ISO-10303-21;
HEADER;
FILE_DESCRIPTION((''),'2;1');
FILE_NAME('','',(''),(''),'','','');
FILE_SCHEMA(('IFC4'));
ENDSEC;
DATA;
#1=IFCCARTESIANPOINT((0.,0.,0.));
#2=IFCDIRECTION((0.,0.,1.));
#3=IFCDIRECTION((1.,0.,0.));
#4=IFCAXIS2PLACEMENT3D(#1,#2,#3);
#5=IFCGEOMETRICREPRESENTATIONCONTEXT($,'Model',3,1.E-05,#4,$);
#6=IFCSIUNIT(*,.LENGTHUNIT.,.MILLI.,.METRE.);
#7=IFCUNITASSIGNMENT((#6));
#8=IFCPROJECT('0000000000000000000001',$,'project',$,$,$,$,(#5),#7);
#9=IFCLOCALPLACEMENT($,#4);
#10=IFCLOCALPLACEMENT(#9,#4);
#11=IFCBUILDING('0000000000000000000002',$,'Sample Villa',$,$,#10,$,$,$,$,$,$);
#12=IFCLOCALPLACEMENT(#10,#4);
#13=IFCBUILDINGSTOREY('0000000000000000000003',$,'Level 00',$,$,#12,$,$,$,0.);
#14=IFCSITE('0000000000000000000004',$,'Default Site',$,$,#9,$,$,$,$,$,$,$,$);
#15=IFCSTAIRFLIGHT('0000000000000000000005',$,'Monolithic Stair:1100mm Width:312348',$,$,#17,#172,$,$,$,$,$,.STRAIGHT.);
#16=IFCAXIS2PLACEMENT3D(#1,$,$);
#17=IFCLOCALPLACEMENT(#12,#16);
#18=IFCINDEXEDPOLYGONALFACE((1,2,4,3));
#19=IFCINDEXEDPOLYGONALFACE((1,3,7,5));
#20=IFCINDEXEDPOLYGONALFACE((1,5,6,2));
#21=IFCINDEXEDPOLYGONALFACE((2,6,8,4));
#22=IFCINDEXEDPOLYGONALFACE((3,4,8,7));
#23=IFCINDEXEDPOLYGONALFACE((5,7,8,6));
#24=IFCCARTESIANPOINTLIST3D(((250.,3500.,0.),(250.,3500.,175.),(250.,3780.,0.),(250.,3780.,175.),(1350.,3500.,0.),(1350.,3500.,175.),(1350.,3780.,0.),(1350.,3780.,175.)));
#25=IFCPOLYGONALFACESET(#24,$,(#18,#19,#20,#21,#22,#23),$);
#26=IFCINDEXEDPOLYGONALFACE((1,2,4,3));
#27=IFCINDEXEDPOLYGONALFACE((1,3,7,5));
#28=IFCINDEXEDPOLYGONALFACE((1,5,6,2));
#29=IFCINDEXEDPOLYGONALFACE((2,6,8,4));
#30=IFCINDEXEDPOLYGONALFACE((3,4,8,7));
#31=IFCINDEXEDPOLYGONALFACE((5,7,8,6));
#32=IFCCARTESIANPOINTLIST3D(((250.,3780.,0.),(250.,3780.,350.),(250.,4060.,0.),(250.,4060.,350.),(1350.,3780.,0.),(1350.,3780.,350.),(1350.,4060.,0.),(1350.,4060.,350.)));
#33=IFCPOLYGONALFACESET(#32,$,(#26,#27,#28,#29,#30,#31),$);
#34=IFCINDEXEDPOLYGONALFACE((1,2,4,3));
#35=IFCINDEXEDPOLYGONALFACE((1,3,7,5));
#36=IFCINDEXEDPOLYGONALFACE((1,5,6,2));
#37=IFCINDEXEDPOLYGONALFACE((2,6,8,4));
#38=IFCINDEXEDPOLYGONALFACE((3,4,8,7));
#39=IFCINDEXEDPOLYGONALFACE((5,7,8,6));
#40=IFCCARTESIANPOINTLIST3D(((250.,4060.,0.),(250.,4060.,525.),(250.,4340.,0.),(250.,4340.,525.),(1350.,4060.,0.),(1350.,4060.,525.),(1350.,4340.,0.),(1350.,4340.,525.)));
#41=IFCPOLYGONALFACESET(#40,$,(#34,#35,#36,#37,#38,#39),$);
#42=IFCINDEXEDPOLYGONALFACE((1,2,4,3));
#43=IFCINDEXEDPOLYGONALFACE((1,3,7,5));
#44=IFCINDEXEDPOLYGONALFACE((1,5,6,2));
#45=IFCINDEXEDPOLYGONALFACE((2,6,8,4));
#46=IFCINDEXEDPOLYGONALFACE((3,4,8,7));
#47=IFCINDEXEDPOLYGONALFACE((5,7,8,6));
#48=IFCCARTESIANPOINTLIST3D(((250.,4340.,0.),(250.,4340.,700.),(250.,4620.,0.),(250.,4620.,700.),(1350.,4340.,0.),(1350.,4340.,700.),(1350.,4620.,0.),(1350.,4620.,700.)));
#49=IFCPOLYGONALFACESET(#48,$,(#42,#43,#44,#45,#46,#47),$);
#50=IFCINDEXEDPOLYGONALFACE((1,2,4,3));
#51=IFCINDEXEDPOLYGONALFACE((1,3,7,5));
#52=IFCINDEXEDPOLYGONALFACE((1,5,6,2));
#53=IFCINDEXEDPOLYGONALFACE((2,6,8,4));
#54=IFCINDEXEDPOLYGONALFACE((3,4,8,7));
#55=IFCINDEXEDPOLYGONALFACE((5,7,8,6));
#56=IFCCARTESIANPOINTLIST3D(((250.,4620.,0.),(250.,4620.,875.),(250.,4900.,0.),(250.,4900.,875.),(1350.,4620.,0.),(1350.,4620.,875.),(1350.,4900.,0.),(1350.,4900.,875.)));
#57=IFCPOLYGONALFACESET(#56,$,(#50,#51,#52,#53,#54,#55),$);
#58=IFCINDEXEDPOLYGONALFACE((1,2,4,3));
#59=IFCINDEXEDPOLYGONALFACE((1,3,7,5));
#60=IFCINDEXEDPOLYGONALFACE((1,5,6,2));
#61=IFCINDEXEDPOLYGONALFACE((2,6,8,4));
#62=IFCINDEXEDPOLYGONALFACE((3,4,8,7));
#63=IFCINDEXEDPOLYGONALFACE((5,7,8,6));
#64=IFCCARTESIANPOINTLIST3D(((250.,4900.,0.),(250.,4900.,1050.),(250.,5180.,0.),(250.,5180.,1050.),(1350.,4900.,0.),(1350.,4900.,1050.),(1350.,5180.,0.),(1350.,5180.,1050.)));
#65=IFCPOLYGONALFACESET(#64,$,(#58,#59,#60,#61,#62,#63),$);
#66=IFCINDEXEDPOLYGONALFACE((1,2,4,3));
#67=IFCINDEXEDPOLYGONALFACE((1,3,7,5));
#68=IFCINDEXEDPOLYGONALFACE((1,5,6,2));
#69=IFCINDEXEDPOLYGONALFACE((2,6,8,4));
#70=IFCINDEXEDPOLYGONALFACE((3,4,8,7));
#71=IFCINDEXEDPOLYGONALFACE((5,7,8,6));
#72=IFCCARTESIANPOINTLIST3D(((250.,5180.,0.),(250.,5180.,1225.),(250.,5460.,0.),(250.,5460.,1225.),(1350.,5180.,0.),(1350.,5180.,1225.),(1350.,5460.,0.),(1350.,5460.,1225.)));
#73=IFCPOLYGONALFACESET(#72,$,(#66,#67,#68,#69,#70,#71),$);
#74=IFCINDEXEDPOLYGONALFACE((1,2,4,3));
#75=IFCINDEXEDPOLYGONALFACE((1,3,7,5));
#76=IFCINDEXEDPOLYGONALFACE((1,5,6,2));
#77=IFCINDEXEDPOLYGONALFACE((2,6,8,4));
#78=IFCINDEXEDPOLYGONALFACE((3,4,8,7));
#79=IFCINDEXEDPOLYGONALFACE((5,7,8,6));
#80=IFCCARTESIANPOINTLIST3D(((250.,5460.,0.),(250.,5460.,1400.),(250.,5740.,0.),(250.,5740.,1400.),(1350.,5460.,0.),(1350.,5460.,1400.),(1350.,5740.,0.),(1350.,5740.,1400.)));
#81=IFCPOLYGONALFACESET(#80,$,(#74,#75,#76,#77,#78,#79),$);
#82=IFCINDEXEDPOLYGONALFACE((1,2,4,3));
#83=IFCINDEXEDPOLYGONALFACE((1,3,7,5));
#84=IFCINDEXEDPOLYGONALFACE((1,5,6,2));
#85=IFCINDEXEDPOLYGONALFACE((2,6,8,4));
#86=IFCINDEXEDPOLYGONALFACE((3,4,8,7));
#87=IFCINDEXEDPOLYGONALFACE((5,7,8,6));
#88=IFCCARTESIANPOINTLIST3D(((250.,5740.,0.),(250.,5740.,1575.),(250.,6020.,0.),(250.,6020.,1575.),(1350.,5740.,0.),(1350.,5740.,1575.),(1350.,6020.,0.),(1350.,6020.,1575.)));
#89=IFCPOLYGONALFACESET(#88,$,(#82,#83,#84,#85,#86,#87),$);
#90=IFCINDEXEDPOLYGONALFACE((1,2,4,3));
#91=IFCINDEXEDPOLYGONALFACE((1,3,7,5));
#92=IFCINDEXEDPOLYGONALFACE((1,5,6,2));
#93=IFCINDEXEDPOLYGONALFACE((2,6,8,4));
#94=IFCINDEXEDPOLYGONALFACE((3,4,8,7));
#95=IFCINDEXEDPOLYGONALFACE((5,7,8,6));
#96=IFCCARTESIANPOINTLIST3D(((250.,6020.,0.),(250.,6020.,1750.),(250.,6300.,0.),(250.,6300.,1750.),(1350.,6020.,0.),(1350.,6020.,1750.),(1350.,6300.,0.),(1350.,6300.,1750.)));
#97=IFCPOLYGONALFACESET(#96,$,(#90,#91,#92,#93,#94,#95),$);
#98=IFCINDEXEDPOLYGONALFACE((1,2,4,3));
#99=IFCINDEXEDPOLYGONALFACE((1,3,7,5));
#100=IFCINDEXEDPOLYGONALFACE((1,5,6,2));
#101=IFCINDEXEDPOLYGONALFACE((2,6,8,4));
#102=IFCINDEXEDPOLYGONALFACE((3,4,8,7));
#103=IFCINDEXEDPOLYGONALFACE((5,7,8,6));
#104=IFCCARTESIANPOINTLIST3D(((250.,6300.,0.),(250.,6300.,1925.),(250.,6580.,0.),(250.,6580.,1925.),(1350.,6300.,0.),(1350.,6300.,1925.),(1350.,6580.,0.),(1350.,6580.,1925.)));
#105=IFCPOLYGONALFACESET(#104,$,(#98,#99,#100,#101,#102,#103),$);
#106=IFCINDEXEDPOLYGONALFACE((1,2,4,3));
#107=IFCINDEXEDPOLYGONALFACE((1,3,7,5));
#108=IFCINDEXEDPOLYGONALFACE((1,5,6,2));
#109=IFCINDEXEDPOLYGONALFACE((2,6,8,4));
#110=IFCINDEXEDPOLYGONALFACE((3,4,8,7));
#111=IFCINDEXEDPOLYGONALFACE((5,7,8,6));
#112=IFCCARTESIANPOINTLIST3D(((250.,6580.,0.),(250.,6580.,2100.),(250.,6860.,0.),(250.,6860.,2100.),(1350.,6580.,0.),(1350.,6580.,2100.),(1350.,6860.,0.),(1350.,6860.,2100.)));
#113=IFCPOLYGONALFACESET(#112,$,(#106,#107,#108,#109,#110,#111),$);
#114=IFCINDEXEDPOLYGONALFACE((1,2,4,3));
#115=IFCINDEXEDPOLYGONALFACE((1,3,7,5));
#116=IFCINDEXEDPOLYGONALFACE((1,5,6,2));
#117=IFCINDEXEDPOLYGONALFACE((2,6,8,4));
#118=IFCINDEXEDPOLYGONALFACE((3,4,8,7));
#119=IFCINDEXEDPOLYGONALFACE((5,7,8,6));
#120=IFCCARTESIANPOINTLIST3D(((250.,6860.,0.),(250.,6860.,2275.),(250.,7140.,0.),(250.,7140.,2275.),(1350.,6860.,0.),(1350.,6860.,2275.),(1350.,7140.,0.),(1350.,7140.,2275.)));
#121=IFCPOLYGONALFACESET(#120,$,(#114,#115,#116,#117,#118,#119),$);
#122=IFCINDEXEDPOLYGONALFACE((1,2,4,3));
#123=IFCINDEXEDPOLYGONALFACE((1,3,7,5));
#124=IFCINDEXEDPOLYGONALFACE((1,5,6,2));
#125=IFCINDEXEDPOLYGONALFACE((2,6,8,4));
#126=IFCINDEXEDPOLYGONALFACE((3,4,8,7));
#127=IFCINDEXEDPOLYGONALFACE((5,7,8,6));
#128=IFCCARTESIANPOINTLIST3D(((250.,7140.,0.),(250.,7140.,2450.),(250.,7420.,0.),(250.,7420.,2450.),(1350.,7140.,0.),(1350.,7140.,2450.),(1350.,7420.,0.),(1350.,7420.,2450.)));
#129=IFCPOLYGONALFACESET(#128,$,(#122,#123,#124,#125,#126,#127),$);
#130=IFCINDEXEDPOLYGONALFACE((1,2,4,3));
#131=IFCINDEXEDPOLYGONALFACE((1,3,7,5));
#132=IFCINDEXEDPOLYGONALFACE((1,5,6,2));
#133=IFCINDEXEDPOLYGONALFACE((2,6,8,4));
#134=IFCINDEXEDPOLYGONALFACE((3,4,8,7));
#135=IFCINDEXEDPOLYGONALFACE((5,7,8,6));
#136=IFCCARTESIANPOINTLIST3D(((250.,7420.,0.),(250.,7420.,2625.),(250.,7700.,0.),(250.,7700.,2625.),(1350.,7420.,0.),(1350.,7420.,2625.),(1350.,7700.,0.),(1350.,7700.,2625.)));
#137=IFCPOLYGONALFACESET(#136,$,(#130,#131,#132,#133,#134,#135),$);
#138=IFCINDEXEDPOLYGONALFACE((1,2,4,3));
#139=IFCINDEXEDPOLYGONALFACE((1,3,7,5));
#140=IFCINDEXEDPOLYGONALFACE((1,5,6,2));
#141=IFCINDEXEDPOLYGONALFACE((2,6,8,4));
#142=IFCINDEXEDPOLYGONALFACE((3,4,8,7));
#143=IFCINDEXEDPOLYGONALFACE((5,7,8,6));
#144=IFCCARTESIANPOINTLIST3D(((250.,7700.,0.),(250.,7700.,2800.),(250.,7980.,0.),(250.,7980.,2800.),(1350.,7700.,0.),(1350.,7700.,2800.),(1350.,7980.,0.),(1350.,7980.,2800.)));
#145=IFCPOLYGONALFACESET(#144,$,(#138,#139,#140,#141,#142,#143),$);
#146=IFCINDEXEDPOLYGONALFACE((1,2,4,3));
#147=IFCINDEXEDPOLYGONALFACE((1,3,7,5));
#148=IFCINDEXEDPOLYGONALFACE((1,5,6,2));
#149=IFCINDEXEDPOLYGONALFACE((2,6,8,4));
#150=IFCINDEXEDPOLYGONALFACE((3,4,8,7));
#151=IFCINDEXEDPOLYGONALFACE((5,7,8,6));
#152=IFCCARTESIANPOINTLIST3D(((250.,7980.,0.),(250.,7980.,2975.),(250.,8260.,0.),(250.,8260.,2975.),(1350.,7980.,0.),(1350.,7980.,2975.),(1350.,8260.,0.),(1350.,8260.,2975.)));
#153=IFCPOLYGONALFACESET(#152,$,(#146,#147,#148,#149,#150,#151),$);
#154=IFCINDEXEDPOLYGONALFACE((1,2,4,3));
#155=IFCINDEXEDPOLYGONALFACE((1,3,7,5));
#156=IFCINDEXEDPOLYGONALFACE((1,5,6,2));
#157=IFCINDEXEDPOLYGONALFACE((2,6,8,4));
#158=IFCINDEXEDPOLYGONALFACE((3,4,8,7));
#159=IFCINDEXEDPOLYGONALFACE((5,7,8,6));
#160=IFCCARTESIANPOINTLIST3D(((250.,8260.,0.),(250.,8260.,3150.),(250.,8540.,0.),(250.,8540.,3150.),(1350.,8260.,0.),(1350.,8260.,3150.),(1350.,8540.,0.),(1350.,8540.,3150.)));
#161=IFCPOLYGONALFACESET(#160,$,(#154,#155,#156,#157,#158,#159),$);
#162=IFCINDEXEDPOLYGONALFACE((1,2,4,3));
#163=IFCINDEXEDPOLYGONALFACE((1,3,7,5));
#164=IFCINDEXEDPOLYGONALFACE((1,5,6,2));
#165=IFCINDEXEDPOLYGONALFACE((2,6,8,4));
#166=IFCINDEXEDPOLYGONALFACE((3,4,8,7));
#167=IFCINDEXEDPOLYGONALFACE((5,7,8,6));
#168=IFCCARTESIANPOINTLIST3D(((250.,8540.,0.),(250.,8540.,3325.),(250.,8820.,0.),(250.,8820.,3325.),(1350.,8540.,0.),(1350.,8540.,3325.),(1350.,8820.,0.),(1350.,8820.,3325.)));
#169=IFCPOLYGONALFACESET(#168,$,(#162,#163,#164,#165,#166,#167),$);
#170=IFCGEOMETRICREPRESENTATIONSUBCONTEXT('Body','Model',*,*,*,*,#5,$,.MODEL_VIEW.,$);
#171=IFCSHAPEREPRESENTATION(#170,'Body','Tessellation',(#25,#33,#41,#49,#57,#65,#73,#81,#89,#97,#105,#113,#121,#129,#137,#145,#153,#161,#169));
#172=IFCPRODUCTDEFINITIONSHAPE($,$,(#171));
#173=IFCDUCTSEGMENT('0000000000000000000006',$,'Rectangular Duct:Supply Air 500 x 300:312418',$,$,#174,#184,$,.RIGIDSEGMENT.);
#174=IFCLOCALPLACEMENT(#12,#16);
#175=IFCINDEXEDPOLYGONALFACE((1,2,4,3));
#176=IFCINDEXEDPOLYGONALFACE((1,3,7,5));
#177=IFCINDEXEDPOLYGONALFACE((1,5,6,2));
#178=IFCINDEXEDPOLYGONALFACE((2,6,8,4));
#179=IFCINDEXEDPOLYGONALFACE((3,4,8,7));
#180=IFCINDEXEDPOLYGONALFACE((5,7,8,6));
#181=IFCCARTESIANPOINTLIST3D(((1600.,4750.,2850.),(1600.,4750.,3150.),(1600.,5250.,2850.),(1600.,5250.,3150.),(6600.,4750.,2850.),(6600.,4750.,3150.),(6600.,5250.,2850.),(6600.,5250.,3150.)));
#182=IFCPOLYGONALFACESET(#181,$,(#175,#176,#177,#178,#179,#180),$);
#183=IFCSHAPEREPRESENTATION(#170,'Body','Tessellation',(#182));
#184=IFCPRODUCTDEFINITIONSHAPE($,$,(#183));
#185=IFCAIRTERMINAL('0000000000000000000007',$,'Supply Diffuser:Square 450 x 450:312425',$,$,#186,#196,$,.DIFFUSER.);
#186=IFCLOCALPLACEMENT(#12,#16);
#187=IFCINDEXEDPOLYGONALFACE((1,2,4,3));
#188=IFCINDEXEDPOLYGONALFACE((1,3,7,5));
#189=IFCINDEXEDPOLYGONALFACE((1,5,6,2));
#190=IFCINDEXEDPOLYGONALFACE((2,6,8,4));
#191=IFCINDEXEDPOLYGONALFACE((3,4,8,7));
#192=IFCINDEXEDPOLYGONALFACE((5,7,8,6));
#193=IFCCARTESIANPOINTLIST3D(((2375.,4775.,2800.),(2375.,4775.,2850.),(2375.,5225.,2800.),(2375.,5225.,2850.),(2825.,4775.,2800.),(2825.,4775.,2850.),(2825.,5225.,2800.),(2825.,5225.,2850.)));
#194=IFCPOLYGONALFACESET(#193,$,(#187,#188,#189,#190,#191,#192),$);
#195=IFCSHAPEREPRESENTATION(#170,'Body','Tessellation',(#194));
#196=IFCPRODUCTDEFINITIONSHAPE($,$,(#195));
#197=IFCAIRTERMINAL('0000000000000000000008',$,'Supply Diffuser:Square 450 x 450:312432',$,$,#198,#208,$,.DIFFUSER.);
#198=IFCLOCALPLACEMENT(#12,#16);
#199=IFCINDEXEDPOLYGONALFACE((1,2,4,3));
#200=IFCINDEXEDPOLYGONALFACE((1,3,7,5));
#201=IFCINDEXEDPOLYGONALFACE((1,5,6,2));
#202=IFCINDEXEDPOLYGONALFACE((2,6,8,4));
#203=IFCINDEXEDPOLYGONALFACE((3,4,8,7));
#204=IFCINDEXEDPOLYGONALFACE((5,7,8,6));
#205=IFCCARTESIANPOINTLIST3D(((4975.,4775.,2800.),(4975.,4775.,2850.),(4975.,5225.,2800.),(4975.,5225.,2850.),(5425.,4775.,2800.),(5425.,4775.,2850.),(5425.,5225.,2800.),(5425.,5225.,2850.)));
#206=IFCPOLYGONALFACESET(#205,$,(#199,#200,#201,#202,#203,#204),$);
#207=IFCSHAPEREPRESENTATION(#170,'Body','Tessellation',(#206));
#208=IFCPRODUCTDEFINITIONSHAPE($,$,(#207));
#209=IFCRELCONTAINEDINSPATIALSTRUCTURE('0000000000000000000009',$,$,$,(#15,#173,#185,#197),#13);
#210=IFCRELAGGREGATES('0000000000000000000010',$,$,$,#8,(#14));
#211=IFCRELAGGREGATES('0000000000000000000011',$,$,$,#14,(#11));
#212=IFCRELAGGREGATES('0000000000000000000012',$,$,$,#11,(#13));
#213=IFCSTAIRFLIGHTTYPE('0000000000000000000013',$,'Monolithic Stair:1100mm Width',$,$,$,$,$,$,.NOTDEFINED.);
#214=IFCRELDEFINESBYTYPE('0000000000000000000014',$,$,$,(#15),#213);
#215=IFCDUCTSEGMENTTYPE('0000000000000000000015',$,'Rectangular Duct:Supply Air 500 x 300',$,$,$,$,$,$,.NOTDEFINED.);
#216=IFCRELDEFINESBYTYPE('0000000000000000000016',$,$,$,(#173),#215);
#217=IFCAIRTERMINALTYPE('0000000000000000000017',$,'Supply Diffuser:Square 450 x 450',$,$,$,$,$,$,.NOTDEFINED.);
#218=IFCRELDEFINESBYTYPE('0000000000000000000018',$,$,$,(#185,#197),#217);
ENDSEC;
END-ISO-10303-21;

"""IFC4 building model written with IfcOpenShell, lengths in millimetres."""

from ifc_helpers import new_model, si_unit, frame, frame_2d, origin_with_axes, place, context, subcontext, project, spatial, rectangle, extrude, type_object, element, save


model = new_model("IFC4")

# Units and contexts
model_context = context("Model", 3, precision=1e-05, world=origin_with_axes())
body_context = subcontext(model_context, "Body", "Model", "MODEL_VIEW")
ifc_project = project(units=[si_unit("LENGTHUNIT", "METRE", prefix="MILLI")], contexts=[model_context])

# Site, building, storey
site_placement = place(None, origin_with_axes())
site = spatial("IfcSite", under=ifc_project, at=site_placement, Name="Default Site")
building_placement = place(site_placement, origin_with_axes())
building = spatial("IfcBuilding", under=site, at=building_placement, Name="Sample Villa")
storey_placement = place(building_placement, origin_with_axes())
storey = spatial("IfcBuildingStorey", under=building, at=storey_placement, Name="Level 00", Elevation=0.0)

# Stair flight
stair_flight_type = type_object("IfcStairFlightType", Name="Monolithic Stair:1100mm Width", PredefinedType="NOTDEFINED")
stair_flight_placement = place(storey_placement, origin_with_axes())
element("IfcStairFlight", 1, at=stair_flight_placement, inside=storey, type_object=stair_flight_type, Name="Monolithic Stair:1100mm Width:312348", PredefinedType="STRAIGHT", context=body_context, shape_type="SweptSolid", body=[
    extrude(rectangle(XDim=1100.0, YDim=280.0, at=frame_2d((550.0, 140.0))), frame((250.0, 3500.0, 0.0)), (0.0, 0.0, 1.0), 175.0),
    extrude(rectangle(XDim=1100.0, YDim=280.0, at=frame_2d((550.0, 140.0))), frame((250.0, 3780.0, 0.0)), (0.0, 0.0, 1.0), 350.0),
    extrude(rectangle(XDim=1100.0, YDim=280.0, at=frame_2d((550.0, 140.0))), frame((250.0, 4060.0, 0.0)), (0.0, 0.0, 1.0), 525.0),
    extrude(rectangle(XDim=1100.0, YDim=280.0, at=frame_2d((550.0, 140.0))), frame((250.0, 4340.0, 0.0)), (0.0, 0.0, 1.0), 700.0),
    extrude(rectangle(XDim=1100.0, YDim=280.0, at=frame_2d((550.0, 140.0))), frame((250.0, 4620.0, 0.0)), (0.0, 0.0, 1.0), 875.0),
    extrude(rectangle(XDim=1100.0, YDim=280.0, at=frame_2d((550.0, 140.0))), frame((250.0, 4900.0, 0.0)), (0.0, 0.0, 1.0), 1050.0),
    extrude(rectangle(XDim=1100.0, YDim=280.0, at=frame_2d((550.0, 140.0))), frame((250.0, 5180.0, 0.0)), (0.0, 0.0, 1.0), 1225.0),
    extrude(rectangle(XDim=1100.0, YDim=280.0, at=frame_2d((550.0, 140.0))), frame((250.0, 5460.0, 0.0)), (0.0, 0.0, 1.0), 1400.0),
    extrude(rectangle(XDim=1100.0, YDim=280.0, at=frame_2d((550.0, 140.0))), frame((250.0, 5740.0, 0.0)), (0.0, 0.0, 1.0), 1575.0),
    extrude(rectangle(XDim=1100.0, YDim=280.0, at=frame_2d((550.0, 140.0))), frame((250.0, 6020.0, 0.0)), (0.0, 0.0, 1.0), 1750.0),
    extrude(rectangle(XDim=1100.0, YDim=280.0, at=frame_2d((550.0, 140.0))), frame((250.0, 6300.0, 0.0)), (0.0, 0.0, 1.0), 1925.0),
    extrude(rectangle(XDim=1100.0, YDim=280.0, at=frame_2d((550.0, 140.0))), frame((250.0, 6580.0, 0.0)), (0.0, 0.0, 1.0), 2100.0),
    extrude(rectangle(XDim=1100.0, YDim=280.0, at=frame_2d((550.0, 140.0))), frame((250.0, 6860.0, 0.0)), (0.0, 0.0, 1.0), 2275.0),
    extrude(rectangle(XDim=1100.0, YDim=280.0, at=frame_2d((550.0, 140.0))), frame((250.0, 7140.0, 0.0)), (0.0, 0.0, 1.0), 2450.0),
    extrude(rectangle(XDim=1100.0, YDim=280.0, at=frame_2d((550.0, 140.0))), frame((250.0, 7420.0, 0.0)), (0.0, 0.0, 1.0), 2625.0),
    extrude(rectangle(XDim=1100.0, YDim=280.0, at=frame_2d((550.0, 140.0))), frame((250.0, 7700.0, 0.0)), (0.0, 0.0, 1.0), 2800.0),
    extrude(rectangle(XDim=1100.0, YDim=280.0, at=frame_2d((550.0, 140.0))), frame((250.0, 7980.0, 0.0)), (0.0, 0.0, 1.0), 2975.0),
    extrude(rectangle(XDim=1100.0, YDim=280.0, at=frame_2d((550.0, 140.0))), frame((250.0, 8260.0, 0.0)), (0.0, 0.0, 1.0), 3150.0),
    extrude(rectangle(XDim=1100.0, YDim=280.0, at=frame_2d((550.0, 140.0))), frame((250.0, 8540.0, 0.0)), (0.0, 0.0, 1.0), 3325.0),
])

# Duct segment
duct_segment_type = type_object("IfcDuctSegmentType", Name="Rectangular Duct:Supply Air 500 x 300", PredefinedType="NOTDEFINED")
duct_segment_placement = place(storey_placement, origin_with_axes())
element("IfcDuctSegment", 2, at=duct_segment_placement, inside=storey, type_object=duct_segment_type, Name="Rectangular Duct:Supply Air 500 x 300:312418", PredefinedType="RIGIDSEGMENT", context=body_context, shape_type="SweptSolid", body=[
    extrude(rectangle(XDim=5000.0, YDim=500.0, at=frame_2d((2500.0, 250.0))), frame((1600.0, 4750.0, 2850.0)), (0.0, 0.0, 1.0), 300.0),
])

# Air terminals
air_terminal_type = type_object("IfcAirTerminalType", Name="Supply Diffuser:Square 450 x 450", PredefinedType="NOTDEFINED")
air_terminal_1_placement = place(storey_placement, origin_with_axes())
element("IfcAirTerminal", 3, at=air_terminal_1_placement, inside=storey, type_object=air_terminal_type, Name="Supply Diffuser:Square 450 x 450:312425", PredefinedType="DIFFUSER", context=body_context, shape_type="SweptSolid", body=[
    extrude(rectangle(XDim=450.0, YDim=450.0, at=frame_2d((225.0, 225.0))), frame((2375.0, 4775.0, 2800.0)), (0.0, 0.0, 1.0), 50.0),
])
air_terminal_2_placement = place(storey_placement, origin_with_axes())
element("IfcAirTerminal", 4, at=air_terminal_2_placement, inside=storey, type_object=air_terminal_type, Name="Supply Diffuser:Square 450 x 450:312432", PredefinedType="DIFFUSER", context=body_context, shape_type="SweptSolid", body=[
    extrude(rectangle(XDim=450.0, YDim=450.0, at=frame_2d((225.0, 225.0))), frame((4975.0, 4775.0, 2800.0)), (0.0, 0.0, 1.0), 50.0),
])

save(model, "model.ifc")
